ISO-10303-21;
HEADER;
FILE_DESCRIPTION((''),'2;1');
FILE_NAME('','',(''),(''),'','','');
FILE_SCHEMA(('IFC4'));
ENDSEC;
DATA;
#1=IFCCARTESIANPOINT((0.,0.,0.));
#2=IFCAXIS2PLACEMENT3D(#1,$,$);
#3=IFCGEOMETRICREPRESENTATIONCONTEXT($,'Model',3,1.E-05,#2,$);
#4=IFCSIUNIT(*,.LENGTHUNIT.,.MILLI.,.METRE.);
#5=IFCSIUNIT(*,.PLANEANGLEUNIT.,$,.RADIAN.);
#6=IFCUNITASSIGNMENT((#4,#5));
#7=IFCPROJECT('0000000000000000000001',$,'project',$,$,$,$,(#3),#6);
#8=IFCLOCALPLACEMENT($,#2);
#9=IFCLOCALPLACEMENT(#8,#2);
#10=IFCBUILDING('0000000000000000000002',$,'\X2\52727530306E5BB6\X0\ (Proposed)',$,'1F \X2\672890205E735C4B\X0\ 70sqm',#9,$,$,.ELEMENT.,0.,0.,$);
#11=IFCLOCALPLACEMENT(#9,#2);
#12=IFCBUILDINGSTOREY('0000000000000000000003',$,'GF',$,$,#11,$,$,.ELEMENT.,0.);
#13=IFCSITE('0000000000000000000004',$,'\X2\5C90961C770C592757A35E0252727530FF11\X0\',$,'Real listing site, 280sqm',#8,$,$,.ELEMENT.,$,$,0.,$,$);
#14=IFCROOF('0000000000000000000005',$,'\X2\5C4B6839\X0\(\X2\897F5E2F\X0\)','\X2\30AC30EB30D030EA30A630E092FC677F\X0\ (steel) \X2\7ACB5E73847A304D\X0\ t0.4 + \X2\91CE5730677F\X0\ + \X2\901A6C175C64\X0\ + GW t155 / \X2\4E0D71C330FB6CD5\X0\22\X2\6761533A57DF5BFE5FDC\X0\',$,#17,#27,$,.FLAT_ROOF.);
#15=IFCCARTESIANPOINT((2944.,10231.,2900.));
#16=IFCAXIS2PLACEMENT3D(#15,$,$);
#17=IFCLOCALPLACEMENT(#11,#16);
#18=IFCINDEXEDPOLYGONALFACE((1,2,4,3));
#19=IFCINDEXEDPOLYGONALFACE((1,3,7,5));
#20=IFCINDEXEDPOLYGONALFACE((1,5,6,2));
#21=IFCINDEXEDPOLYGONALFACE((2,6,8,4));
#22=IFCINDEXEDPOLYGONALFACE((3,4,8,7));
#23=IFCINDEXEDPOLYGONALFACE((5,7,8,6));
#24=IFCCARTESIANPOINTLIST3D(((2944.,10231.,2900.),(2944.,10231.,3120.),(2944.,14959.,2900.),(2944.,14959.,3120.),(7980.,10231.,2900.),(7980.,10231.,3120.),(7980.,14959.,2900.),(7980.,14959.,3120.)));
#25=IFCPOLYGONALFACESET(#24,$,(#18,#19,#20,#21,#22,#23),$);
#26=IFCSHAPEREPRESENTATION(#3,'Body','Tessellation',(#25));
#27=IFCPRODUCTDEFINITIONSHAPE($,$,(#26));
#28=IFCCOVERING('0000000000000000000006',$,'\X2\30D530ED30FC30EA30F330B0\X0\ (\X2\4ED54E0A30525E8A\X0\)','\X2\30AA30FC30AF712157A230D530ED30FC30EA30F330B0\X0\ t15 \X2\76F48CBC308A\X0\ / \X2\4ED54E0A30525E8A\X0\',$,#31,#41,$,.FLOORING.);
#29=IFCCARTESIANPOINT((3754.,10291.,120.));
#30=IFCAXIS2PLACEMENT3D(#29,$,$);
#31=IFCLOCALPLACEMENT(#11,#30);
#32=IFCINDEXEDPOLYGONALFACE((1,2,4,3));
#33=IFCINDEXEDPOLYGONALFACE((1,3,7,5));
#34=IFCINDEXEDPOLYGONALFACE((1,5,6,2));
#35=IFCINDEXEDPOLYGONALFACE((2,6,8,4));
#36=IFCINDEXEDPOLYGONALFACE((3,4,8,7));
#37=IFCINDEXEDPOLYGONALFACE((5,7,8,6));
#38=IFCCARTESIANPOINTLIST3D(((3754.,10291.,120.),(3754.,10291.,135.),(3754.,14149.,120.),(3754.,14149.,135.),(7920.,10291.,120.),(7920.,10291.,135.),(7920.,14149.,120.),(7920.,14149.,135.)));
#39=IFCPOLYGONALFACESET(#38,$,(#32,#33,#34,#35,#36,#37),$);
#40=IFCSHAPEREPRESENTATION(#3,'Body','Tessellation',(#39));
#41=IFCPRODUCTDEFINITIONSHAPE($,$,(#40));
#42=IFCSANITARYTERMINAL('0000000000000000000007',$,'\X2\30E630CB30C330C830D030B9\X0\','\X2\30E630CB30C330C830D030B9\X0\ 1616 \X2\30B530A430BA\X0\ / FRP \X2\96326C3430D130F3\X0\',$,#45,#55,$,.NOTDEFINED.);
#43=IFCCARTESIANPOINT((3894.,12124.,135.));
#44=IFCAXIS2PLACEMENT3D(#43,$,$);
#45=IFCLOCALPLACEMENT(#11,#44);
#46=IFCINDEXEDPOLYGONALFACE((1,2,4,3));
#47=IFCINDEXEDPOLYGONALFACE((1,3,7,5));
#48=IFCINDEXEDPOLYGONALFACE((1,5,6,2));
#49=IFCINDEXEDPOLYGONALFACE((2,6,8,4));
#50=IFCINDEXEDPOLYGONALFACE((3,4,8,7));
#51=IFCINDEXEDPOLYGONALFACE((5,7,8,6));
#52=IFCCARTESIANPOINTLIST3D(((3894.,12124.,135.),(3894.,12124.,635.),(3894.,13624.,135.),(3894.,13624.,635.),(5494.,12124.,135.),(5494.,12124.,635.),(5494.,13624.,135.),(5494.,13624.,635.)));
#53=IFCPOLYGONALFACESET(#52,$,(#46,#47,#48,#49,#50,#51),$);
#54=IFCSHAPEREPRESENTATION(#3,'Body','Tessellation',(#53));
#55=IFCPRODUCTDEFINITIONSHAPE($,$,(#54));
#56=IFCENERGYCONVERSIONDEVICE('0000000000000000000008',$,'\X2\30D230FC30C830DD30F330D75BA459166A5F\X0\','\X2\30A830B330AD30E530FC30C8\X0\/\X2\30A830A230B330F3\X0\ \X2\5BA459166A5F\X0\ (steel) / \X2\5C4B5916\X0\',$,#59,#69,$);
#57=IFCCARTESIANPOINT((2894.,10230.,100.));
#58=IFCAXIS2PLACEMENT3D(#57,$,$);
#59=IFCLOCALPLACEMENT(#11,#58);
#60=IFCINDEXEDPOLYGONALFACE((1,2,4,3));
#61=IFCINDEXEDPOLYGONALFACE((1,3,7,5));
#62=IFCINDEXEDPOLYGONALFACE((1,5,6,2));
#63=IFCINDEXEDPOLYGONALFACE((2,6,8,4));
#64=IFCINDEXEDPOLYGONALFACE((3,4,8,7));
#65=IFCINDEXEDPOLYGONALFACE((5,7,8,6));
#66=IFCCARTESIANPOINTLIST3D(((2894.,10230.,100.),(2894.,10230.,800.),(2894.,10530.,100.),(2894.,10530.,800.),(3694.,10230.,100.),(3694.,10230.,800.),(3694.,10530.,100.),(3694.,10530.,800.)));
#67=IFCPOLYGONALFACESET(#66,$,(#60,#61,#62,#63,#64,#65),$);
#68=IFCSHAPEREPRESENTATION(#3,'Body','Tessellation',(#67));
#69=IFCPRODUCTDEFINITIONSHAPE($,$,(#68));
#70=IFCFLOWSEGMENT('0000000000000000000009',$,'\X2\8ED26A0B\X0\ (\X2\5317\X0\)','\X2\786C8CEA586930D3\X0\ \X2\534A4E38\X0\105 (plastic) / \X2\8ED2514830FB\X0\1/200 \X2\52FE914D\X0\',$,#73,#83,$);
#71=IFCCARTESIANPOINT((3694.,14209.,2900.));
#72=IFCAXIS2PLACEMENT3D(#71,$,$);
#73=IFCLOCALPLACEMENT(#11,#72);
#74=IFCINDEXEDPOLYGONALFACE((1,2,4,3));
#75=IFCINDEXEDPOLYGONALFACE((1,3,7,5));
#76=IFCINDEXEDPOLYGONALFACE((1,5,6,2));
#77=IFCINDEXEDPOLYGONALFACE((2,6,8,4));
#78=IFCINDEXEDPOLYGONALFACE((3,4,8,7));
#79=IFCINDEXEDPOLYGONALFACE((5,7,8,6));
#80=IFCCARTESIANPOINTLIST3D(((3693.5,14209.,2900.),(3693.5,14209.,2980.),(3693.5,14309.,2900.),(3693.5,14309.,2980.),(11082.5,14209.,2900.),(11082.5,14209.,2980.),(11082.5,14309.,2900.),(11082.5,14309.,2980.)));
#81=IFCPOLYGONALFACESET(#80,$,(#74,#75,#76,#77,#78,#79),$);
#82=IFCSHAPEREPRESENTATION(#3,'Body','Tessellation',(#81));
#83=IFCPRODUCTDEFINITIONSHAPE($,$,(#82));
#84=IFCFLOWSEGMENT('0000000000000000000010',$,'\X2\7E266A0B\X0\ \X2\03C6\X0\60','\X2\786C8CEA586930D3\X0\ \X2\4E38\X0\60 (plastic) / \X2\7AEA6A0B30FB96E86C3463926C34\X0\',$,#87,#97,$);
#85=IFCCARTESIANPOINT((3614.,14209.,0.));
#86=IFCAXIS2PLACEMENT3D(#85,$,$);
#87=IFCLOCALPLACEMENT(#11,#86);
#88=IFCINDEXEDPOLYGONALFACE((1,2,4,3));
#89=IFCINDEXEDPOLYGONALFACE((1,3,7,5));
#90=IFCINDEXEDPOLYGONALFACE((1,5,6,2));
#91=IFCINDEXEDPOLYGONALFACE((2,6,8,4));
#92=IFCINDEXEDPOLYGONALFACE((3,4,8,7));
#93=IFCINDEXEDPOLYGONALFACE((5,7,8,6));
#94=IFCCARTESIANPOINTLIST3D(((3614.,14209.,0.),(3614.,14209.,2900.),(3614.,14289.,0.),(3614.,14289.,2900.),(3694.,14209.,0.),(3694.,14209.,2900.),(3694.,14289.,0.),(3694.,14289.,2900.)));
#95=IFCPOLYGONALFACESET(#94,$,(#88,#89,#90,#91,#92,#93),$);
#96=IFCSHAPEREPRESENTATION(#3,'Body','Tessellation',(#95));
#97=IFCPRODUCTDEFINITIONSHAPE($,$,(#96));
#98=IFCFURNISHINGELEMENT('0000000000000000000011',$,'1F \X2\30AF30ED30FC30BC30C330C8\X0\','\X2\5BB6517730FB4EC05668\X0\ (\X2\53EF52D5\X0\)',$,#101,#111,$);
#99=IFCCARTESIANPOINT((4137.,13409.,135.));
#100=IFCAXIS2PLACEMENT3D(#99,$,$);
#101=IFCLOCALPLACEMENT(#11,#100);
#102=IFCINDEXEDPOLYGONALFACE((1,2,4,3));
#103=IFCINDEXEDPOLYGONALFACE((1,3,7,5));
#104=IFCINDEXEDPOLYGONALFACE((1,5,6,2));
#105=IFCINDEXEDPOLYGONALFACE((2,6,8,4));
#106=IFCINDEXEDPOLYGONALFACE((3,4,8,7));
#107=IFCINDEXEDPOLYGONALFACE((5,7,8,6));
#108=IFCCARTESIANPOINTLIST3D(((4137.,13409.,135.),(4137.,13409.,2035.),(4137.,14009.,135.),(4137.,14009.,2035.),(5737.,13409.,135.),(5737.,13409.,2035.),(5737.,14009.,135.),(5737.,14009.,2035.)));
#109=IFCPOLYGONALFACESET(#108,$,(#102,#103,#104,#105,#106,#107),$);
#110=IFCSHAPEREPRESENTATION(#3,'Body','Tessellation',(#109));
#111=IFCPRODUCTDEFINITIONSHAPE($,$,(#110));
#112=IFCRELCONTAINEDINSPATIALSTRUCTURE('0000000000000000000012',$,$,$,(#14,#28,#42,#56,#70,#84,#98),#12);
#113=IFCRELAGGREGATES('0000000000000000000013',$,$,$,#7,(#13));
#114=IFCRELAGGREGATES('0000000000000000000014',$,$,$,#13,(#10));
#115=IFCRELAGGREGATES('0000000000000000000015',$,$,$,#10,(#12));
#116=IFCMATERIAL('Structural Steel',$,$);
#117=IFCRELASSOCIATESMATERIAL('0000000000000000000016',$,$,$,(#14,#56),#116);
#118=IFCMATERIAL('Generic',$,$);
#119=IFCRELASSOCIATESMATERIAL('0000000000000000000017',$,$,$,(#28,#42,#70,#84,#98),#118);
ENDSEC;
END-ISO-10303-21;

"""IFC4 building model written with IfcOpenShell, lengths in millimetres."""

from ifc_helpers import new_model, si_unit, frame, frame_2d, origin, place, context, project, spatial, rectangle, extrude, material, element, save


model = new_model("IFC4")

# Units and contexts
model_context = context("Model", 3, precision=1e-05, world=origin())
ifc_project = project(units=[si_unit("LENGTHUNIT", "METRE", prefix="MILLI"), si_unit("PLANEANGLEUNIT", "RADIAN")], contexts=[model_context])

# Site, building, storey
site_placement = place(None, origin())
site = spatial("IfcSite", under=ifc_project, at=site_placement, Name="岐阜県大垣市割田１", ObjectType="Real listing site, 280sqm", CompositionType="ELEMENT", RefElevation=0.0)
building_placement = place(site_placement, origin())
building = spatial("IfcBuilding", under=site, at=building_placement, Name="割田の家 (Proposed)", ObjectType="1F 木造平屋 70sqm", CompositionType="ELEMENT", ElevationOfRefHeight=0.0, ElevationOfTerrain=0.0)
storey_placement = place(building_placement, origin())
storey = spatial("IfcBuildingStorey", under=building, at=storey_placement, Name="GF", CompositionType="ELEMENT", Elevation=0.0)

# Roof
ifc_material_1 = material(Name="Structural Steel")
roof_placement = place(storey_placement, frame((2944.0, 10231.0, 2900.0)))
element("IfcRoof", 1, at=roof_placement, inside=storey, material=ifc_material_1, Name="屋根(西帯)", Description="ガルバリウム鋼板 (steel) 立平葺き t0.4 + 野地板 + 通気層 + GW t155 / 不燃・法22条区域対応", PredefinedType="FLAT_ROOF", context=model_context, shape_type="SweptSolid", body=[
    extrude(rectangle(XDim=5036.0, YDim=4728.0, at=frame_2d((2518.0, 2364.0))), frame((2944.0, 10231.0, 2900.0)), (0.0, 0.0, 1.0), 220.0),
])

# Covering
ifc_material_2 = material(Name="Generic")
covering_placement = place(storey_placement, frame((3754.0, 10291.0, 120.0)))
element("IfcCovering", 2, at=covering_placement, inside=storey, material=ifc_material_2, Name="フローリング (仕上げ床)", Description="オーク無垢フローリング t15 直貼り / 仕上げ床", PredefinedType="FLOORING", context=model_context, shape_type="SweptSolid", body=[
    extrude(rectangle(XDim=4166.0, YDim=3858.0, at=frame_2d((2083.0, 1929.0))), frame((3754.0, 10291.0, 120.0)), (0.0, 0.0, 1.0), 15.0),
])

# Sanitary terminal
sanitary_terminal_placement = place(storey_placement, frame((3894.0, 12124.0, 135.0)))
element("IfcSanitaryTerminal", 3, at=sanitary_terminal_placement, inside=storey, material=ifc_material_2, Name="ユニットバス", Description="ユニットバス 1616 サイズ / FRP 防水パン", PredefinedType="NOTDEFINED", context=model_context, shape_type="SweptSolid", body=[
    extrude(rectangle(XDim=1600.0, YDim=1500.0, at=frame_2d((800.0, 750.0))), frame((3894.0, 12124.0, 135.0)), (0.0, 0.0, 1.0), 500.0),
])

# Energy conversion device
energy_conversion_device_placement = place(storey_placement, frame((2894.0, 10230.0, 100.0)))
element("IfcEnergyConversionDevice", 4, at=energy_conversion_device_placement, inside=storey, material=ifc_material_1, Name="ヒートポンプ室外機", Description="エコキュート/エアコン 室外機 (steel) / 屋外", context=model_context, shape_type="SweptSolid", body=[
    extrude(rectangle(XDim=800.0, YDim=300.0, at=frame_2d((400.0, 150.0))), frame((2894.0, 10230.0, 100.0)), (0.0, 0.0, 1.0), 700.0),
])

# Flow segments
flow_segment_1_placement = place(storey_placement, frame((3694.0, 14209.0, 2900.0)))
element("IfcFlowSegment", 5, at=flow_segment_1_placement, inside=storey, material=ifc_material_2, Name="軒樋 (北)", Description="硬質塩ビ 半丸105 (plastic) / 軒先・1/200 勾配", context=model_context, shape_type="SweptSolid", body=[
    extrude(rectangle(XDim=7389.0, YDim=100.0, at=frame_2d((3694.0, 50.0))), frame((3694.0, 14209.0, 2900.0)), (0.0, 0.0, 1.0), 80.0),
])
flow_segment_2_placement = place(storey_placement, frame((3614.0, 14209.0, 0.0)))
element("IfcFlowSegment", 6, at=flow_segment_2_placement, inside=storey, material=ifc_material_2, Name="縦樋 φ60", Description="硬質塩ビ 丸60 (plastic) / 竪樋・雨水排水", context=model_context, shape_type="SweptSolid", body=[
    extrude(rectangle(XDim=80.0, YDim=80.0, at=frame_2d((40.0, 40.0))), frame((3614.0, 14209.0, 0.0)), (0.0, 0.0, 1.0), 2900.0),
])

# Furnishing element
furnishing_placement = place(storey_placement, frame((4137.0, 13409.0, 135.0)))
element("IfcFurnishingElement", 7, at=furnishing_placement, inside=storey, material=ifc_material_2, Name="1F クローゼット", Description="家具・什器 (可動)", context=model_context, shape_type="SweptSolid", body=[
    extrude(rectangle(XDim=1600.0, YDim=600.0, at=frame_2d((800.0, 300.0))), frame((4137.0, 13409.0, 135.0)), (0.0, 0.0, 1.0), 1900.0),
])

save(model, "model.ifc")
